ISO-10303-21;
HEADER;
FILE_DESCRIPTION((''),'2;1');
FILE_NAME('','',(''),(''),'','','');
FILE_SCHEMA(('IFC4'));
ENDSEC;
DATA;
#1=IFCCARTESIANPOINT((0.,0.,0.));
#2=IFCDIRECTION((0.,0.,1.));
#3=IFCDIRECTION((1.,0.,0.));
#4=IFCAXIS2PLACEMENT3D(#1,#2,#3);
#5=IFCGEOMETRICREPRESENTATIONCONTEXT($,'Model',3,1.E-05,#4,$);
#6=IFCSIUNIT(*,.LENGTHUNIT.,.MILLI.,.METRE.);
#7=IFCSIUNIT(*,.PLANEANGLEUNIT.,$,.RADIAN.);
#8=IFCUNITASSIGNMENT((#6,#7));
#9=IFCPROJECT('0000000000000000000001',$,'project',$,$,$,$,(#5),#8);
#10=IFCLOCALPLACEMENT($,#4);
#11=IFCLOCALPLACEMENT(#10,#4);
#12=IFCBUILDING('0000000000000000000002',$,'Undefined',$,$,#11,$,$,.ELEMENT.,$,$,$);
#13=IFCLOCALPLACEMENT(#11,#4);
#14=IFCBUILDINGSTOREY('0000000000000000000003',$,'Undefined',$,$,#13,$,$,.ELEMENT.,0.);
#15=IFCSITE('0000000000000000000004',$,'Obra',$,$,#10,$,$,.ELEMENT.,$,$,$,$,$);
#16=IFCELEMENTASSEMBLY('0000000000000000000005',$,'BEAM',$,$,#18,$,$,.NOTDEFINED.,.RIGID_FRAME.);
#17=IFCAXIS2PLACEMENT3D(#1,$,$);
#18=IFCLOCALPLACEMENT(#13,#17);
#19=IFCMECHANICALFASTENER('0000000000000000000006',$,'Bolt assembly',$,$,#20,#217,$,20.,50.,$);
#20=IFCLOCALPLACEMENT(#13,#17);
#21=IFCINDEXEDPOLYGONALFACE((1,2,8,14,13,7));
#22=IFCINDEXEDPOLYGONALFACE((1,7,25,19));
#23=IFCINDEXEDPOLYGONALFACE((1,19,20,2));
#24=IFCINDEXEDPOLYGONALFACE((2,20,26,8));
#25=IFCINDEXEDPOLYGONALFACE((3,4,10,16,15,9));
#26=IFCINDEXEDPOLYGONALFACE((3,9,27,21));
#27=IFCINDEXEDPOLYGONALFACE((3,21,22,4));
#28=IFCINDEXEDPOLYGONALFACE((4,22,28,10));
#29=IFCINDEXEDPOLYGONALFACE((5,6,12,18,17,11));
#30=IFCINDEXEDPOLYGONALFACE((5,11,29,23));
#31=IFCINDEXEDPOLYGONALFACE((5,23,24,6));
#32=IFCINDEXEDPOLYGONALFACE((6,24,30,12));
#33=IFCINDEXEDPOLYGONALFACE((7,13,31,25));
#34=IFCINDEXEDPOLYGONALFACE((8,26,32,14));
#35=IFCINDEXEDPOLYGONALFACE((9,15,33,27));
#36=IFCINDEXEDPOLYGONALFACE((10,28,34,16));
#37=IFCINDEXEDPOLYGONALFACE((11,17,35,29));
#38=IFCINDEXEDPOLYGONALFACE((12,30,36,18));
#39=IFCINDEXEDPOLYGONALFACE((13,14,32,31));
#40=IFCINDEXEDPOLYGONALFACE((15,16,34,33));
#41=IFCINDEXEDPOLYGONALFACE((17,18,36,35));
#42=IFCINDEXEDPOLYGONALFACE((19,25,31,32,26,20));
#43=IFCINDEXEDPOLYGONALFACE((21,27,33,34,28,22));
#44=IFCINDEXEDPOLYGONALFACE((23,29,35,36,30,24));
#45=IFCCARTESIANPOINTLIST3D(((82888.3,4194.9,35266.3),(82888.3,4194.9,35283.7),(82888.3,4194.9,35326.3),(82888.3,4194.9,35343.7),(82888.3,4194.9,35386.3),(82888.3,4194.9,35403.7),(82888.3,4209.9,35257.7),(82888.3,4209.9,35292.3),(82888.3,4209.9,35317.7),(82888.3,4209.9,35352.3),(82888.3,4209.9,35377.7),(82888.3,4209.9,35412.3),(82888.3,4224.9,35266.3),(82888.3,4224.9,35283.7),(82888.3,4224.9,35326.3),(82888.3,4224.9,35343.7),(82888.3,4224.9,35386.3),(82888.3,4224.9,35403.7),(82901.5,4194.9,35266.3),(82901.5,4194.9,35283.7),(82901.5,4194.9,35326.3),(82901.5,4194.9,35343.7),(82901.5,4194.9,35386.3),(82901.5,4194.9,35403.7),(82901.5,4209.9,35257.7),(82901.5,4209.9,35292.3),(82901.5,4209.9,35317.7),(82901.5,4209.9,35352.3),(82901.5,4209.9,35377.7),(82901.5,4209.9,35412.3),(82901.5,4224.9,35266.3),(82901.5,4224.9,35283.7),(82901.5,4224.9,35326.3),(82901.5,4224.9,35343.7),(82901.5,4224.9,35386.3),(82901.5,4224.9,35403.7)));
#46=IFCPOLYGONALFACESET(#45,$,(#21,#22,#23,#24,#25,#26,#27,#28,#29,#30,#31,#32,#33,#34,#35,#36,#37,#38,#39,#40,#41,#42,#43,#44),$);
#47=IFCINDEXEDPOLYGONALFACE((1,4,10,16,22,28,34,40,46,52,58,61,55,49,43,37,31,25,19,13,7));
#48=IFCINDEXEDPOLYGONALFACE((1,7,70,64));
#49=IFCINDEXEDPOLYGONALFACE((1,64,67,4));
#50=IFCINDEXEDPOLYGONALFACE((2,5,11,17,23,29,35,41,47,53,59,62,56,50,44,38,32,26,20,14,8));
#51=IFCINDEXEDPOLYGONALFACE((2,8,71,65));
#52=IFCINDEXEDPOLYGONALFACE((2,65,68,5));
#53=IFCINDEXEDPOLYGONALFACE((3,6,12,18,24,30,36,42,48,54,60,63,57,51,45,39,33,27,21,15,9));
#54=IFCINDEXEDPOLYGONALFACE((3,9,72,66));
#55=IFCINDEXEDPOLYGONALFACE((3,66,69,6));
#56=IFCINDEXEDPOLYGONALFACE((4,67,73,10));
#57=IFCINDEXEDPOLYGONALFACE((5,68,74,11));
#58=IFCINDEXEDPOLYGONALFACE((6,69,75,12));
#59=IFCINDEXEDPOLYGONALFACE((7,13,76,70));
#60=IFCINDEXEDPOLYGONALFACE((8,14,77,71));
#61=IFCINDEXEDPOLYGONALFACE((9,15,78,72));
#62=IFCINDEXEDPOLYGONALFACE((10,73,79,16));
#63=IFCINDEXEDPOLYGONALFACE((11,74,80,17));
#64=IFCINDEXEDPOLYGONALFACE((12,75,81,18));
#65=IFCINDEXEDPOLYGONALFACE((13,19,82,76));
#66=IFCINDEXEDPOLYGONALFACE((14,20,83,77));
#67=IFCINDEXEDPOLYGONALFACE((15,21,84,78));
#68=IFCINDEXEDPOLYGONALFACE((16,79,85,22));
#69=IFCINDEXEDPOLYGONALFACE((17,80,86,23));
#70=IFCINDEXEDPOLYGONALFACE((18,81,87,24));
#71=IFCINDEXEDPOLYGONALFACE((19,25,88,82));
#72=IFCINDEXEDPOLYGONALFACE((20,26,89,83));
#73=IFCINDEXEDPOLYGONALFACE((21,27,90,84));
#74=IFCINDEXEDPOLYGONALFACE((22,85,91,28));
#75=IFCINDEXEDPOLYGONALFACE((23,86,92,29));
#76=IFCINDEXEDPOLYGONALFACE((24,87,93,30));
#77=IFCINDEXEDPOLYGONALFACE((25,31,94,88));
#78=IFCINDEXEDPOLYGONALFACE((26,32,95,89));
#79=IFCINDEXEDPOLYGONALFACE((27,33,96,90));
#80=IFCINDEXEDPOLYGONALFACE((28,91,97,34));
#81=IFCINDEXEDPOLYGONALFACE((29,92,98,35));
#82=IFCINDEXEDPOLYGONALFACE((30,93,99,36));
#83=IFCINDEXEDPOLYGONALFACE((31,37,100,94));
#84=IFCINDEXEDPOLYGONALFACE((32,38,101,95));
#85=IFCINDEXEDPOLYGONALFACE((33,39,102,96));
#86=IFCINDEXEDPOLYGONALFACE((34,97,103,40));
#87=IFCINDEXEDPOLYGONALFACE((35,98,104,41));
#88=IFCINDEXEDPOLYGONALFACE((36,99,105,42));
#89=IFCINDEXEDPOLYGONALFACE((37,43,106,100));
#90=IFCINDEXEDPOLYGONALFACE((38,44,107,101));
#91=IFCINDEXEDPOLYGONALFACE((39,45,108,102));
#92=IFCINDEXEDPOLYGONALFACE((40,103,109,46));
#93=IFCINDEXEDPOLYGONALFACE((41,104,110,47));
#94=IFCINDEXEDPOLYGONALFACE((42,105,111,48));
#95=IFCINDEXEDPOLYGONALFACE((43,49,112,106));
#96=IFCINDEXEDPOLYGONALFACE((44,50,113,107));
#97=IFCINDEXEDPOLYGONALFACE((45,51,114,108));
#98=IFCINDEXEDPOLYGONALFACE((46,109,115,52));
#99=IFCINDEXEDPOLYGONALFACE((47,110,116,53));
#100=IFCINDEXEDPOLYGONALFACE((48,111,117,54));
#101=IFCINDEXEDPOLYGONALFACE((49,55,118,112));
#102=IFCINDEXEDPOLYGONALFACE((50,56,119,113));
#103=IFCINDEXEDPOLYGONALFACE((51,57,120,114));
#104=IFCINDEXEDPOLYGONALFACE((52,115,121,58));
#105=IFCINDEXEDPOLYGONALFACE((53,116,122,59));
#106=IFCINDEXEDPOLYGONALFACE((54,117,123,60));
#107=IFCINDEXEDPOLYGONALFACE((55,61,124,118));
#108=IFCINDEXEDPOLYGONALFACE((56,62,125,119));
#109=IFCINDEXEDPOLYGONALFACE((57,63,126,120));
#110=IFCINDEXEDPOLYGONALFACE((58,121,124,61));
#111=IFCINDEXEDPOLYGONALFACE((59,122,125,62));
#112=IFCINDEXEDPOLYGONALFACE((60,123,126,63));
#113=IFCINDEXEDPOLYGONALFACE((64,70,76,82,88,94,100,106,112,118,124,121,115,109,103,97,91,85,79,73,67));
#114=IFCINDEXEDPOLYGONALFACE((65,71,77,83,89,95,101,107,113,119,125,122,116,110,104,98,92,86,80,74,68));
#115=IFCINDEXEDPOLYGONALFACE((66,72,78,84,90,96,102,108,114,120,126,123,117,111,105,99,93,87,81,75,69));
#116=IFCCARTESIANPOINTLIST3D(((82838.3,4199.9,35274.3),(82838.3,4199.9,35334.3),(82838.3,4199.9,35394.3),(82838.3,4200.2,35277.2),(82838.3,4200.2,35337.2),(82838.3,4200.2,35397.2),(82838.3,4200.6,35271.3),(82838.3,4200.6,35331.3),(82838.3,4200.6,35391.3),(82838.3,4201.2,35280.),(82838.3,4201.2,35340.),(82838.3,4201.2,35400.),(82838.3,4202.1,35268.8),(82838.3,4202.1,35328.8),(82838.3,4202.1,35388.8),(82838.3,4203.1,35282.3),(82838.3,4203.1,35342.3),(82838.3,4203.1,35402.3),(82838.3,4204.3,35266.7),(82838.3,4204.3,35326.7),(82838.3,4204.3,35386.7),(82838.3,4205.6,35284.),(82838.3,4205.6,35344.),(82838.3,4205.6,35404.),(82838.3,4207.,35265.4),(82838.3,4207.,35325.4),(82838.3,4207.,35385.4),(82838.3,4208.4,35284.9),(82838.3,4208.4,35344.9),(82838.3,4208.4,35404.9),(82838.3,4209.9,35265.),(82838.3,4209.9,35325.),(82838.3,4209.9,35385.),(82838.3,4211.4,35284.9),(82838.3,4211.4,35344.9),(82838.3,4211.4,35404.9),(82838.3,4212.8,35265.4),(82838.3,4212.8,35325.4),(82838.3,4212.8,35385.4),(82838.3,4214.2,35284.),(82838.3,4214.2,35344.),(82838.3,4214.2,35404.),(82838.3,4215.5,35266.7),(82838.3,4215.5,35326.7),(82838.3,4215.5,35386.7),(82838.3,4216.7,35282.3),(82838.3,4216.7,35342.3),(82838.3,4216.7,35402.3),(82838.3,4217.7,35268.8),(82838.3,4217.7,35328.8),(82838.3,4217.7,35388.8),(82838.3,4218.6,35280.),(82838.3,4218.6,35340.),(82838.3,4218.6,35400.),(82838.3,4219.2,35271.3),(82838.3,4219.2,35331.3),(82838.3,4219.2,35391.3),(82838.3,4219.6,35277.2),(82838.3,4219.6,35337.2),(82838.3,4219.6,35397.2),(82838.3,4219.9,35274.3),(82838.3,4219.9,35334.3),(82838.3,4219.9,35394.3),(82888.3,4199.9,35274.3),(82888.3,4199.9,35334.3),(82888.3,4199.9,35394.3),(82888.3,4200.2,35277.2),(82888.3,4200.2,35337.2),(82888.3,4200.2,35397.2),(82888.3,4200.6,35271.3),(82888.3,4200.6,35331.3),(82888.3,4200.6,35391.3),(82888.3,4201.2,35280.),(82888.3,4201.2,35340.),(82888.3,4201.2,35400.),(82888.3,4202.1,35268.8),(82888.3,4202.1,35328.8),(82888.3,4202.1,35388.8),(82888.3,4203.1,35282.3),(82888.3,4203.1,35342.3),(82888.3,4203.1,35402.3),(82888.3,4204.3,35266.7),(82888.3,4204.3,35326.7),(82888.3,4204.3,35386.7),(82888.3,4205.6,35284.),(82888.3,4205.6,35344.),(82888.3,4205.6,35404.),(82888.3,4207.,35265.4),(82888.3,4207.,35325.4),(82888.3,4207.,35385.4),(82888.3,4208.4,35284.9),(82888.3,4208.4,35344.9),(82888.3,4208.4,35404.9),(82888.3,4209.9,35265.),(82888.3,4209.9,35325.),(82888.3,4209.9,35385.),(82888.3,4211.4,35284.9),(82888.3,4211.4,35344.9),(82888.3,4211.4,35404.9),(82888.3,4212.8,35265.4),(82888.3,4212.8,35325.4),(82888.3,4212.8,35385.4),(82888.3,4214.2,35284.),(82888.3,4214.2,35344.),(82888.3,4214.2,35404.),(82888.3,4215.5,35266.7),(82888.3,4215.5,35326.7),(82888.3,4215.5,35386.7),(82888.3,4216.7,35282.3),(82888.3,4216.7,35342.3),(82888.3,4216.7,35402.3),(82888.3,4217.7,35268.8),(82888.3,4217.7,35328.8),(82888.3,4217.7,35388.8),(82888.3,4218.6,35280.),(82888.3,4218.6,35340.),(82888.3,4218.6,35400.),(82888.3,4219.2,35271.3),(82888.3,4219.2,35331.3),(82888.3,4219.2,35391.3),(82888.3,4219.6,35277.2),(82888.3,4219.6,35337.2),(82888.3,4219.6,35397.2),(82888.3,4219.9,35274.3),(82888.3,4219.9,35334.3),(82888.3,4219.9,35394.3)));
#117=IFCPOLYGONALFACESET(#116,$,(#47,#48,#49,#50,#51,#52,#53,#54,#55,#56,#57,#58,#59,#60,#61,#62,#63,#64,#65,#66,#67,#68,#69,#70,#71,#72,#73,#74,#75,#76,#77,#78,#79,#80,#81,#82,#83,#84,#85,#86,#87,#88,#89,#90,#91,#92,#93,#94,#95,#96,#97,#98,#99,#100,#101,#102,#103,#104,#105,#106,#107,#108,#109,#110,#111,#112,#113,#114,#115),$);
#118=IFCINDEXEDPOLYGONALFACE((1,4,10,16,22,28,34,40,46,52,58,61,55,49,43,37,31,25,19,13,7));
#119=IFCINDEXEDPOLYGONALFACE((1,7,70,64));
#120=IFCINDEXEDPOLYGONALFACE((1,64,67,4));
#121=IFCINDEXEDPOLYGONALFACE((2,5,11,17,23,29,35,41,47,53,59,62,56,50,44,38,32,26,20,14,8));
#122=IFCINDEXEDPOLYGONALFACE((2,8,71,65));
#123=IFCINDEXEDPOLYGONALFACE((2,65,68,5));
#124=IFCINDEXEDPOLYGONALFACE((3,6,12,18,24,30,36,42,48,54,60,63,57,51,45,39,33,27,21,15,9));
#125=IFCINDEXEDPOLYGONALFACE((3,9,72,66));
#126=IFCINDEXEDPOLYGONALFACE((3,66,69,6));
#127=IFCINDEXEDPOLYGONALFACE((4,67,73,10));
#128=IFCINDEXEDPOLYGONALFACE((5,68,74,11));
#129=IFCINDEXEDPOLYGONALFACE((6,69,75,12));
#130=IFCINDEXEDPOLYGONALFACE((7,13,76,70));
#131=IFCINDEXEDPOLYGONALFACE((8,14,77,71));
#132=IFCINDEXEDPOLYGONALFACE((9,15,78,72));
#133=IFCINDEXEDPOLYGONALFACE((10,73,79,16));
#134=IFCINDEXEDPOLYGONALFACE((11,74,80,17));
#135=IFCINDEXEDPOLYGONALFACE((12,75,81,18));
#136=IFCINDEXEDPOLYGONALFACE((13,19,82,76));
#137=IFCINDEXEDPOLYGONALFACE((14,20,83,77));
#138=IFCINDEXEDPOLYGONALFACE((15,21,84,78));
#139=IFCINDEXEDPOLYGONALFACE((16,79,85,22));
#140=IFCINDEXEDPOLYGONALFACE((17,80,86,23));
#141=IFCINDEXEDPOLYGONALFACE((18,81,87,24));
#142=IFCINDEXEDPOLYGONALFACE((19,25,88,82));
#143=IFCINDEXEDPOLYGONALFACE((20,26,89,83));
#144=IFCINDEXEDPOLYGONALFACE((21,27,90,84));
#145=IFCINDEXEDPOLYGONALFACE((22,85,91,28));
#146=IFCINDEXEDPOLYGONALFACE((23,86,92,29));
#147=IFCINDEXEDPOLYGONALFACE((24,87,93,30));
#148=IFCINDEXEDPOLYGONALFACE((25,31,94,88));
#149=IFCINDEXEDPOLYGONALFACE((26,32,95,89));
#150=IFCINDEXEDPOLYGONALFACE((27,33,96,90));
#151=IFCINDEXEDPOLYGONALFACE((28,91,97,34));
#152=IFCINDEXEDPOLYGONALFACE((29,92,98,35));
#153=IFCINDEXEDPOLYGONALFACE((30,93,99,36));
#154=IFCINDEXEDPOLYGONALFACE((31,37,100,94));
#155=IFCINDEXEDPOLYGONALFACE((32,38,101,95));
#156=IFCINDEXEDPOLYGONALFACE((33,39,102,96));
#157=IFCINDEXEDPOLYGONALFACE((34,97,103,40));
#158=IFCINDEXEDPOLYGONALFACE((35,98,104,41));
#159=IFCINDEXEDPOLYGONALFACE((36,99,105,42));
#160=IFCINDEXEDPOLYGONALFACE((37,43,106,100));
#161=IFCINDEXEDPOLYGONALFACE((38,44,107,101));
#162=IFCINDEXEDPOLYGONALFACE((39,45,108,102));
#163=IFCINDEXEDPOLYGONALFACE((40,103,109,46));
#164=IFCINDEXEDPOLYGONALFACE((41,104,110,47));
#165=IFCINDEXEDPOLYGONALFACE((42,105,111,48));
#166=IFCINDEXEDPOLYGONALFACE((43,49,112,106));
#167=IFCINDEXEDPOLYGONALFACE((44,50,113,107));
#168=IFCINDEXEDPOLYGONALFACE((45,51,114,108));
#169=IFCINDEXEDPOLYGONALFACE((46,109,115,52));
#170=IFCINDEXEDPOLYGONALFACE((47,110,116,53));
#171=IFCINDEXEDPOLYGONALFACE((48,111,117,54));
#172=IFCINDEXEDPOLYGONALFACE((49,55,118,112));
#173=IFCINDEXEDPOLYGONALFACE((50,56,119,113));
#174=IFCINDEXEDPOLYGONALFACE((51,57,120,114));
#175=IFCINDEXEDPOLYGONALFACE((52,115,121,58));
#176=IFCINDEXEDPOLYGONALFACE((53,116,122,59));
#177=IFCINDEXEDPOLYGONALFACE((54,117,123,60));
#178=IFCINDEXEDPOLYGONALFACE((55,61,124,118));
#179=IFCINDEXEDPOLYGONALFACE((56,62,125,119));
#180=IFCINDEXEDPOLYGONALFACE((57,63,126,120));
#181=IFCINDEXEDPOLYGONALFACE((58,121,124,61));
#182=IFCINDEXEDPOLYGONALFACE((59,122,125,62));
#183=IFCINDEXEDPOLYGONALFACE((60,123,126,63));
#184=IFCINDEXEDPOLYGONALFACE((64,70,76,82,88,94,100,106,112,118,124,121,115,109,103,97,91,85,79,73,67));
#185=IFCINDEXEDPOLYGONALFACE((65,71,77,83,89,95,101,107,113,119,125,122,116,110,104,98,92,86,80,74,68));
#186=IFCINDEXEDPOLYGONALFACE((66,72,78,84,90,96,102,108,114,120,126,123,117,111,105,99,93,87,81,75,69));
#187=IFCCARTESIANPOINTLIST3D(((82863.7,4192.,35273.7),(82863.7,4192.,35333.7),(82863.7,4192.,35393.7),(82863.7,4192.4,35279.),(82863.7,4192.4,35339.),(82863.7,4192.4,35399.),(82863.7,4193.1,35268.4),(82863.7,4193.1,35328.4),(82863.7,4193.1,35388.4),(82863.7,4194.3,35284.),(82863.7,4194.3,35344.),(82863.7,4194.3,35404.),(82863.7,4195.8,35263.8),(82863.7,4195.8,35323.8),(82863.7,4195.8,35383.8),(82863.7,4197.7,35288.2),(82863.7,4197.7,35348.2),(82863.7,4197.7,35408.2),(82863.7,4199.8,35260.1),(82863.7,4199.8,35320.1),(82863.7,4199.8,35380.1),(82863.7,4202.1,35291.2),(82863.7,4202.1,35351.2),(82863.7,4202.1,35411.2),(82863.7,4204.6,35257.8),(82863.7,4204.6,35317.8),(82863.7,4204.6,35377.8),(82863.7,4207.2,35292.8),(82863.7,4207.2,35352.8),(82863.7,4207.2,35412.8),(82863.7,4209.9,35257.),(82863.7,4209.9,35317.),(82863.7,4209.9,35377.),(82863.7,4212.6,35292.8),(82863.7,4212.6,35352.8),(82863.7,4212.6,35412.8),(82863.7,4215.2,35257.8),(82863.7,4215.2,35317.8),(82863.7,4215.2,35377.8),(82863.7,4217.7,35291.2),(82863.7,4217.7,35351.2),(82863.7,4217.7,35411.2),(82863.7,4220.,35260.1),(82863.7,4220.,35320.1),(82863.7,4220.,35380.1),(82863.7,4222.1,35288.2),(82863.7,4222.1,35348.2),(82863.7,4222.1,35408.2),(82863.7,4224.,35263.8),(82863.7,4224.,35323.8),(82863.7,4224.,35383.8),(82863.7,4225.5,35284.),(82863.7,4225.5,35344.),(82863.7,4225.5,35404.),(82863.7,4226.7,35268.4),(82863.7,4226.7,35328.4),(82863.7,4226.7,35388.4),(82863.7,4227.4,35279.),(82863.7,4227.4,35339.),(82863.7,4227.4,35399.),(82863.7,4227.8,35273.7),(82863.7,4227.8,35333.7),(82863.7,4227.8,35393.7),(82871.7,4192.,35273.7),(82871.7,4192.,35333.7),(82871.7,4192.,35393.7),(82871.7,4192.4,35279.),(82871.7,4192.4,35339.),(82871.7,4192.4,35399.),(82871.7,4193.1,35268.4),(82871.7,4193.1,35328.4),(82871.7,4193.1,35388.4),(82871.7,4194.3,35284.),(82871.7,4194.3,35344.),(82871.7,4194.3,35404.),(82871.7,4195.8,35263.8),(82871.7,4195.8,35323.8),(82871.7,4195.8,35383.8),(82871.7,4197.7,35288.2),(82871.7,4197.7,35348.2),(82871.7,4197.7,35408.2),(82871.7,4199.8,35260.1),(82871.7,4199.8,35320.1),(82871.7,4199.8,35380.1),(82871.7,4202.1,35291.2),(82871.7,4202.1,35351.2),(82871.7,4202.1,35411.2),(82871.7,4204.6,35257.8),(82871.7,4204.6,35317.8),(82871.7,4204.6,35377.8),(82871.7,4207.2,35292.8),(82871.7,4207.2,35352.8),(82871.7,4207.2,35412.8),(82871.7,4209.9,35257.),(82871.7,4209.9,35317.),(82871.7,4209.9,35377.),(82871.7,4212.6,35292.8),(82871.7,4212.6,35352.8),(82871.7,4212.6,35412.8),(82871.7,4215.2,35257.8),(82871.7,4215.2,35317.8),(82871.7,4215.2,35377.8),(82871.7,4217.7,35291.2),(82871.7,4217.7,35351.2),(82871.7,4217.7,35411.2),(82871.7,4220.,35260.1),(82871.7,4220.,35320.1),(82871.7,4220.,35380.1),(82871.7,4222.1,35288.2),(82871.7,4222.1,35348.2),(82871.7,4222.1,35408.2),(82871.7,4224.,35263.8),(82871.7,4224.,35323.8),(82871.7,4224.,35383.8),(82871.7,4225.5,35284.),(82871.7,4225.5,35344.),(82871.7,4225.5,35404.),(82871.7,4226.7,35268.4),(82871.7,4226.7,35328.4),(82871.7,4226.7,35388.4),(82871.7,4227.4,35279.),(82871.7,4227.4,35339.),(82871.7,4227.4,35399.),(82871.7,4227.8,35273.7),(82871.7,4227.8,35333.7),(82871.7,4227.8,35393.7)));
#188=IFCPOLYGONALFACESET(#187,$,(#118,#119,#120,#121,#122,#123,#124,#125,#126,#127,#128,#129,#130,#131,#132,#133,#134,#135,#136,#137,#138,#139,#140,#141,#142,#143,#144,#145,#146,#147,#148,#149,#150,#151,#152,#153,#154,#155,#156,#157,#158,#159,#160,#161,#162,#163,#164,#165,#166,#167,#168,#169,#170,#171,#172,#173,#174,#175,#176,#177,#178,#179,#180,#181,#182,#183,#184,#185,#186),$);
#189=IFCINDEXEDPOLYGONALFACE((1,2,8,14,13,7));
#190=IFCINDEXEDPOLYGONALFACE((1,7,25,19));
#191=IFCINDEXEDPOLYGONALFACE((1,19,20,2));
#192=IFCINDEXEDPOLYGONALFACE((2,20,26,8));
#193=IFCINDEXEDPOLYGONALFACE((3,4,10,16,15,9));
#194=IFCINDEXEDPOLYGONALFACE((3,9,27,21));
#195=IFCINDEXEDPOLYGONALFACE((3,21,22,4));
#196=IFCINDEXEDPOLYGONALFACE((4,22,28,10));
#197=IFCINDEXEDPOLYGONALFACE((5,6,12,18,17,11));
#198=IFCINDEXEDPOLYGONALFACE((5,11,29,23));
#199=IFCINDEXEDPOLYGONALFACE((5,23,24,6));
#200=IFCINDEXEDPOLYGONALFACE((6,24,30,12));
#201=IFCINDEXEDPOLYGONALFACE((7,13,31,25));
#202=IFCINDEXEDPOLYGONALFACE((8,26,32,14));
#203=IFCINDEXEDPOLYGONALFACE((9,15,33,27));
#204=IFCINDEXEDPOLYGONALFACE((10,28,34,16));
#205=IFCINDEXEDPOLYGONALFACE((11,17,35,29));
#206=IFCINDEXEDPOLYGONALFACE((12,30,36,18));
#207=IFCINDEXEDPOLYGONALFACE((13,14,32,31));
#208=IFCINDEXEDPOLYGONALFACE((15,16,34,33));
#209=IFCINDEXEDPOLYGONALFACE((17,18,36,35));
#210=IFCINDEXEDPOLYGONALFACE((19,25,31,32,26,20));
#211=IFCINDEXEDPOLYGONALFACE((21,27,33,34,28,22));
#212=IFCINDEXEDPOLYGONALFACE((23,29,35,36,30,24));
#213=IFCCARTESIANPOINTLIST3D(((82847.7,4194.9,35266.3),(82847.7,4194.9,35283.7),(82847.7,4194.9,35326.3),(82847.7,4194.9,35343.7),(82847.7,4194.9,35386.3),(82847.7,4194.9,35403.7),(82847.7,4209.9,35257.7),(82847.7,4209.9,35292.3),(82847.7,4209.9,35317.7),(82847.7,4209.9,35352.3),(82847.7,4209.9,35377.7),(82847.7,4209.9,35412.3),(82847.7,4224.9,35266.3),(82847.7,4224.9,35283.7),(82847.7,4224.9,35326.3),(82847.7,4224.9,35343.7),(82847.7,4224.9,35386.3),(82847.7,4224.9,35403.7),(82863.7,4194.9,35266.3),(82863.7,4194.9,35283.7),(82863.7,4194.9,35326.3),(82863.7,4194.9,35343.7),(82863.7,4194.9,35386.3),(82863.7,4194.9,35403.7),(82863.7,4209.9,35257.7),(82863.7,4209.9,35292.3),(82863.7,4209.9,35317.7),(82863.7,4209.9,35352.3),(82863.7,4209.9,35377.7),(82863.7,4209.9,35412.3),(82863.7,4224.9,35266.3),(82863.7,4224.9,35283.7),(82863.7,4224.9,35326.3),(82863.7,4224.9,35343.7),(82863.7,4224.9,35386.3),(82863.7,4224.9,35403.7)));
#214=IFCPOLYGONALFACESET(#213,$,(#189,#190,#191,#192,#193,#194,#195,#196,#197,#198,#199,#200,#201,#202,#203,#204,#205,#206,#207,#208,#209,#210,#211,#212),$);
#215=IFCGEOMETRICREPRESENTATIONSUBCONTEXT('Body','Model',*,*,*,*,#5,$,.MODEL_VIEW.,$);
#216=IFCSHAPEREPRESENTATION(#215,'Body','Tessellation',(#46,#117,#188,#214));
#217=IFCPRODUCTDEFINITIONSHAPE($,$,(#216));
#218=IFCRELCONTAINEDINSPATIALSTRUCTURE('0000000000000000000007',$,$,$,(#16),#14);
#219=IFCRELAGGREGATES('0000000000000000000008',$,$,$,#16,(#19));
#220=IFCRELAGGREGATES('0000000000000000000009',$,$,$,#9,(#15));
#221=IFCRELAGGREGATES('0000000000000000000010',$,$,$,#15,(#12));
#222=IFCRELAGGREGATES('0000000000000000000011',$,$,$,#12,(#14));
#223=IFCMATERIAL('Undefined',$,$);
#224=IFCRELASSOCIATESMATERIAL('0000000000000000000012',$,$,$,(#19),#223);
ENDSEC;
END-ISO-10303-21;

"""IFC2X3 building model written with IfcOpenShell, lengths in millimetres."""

from ifc_helpers import new_model, si_unit, frame, origin_with_axes, origin_2d_with_axis, place, context, subcontext, project, spatial, polyline, circle, outline, extrude, source, transform, mapped, material, element, aggregate, save


model = new_model("IFC2X3")

# Units and contexts
model_context = context("Model", 3, precision=1e-05, world=origin_with_axes())
body_context = subcontext(model_context, "Body", "Model", "MODEL_VIEW")
ifc_project = project(units=[si_unit("LENGTHUNIT", "METRE", prefix="MILLI"), si_unit("PLANEANGLEUNIT", "RADIAN")], contexts=[model_context])

# Site, building, storey
site_placement = place(None, origin_with_axes())
site = spatial("IfcSite", under=ifc_project, at=site_placement, Name="Obra", CompositionType="ELEMENT")
building_placement = place(site_placement, origin_with_axes())
building = spatial("IfcBuilding", under=site, at=building_placement, Name="Undefined", CompositionType="ELEMENT")
storey_placement = place(building_placement, origin_with_axes())
storey = spatial("IfcBuildingStorey", under=building, at=storey_placement, Name="Undefined", CompositionType="ELEMENT", Elevation=0.0)

# Element assembly
assembly_1_placement = place(storey_placement, origin_with_axes())
assembly_1 = element("IfcElementAssembly", 1, at=assembly_1_placement, inside=storey, Name="BEAM", AssemblyPlace="NOTDEFINED", PredefinedType="RIGID_FRAME")

# Shared definitions
ifc_material_1 = material(Name="Undefined")
shared_shape_1 = source(origin_with_axes(), body_context, "Body", "SweptSolid", [
    extrude(outline(polyline([(17.3, 0.0), (8.7, 15.0), (-8.7, 15.0), (-17.3, 0.0), (-8.7, -15.0), (8.7, -15.0), (17.3, 0.0)])), frame((0.0, -26.5, 0.0), z_axis=(0.0, 1.0, 0.0), x_axis=(1.0, 0.0, 0.0)), (0.0, 0.0, 1.0), 13.2),
    extrude(circle(Radius=10.0, at=origin_2d_with_axis()), frame((0.0, -13.3, 0.0), z_axis=(0.0, 1.0, 0.0), x_axis=(1.0, 0.0, 0.0)), (0.0, 0.0, 1.0), 50.0),
    extrude(circle(Radius=18.0, at=origin_2d_with_axis()), frame((0.0, 3.3, 0.0), z_axis=(0.0, 1.0, 0.0), x_axis=(1.0, 0.0, 0.0)), (0.0, 0.0, 1.0), 8.0),
    extrude(outline(polyline([(17.3, 0.0), (8.7, 15.0), (-8.7, 15.0), (-17.3, 0.0), (-8.7, -15.0), (8.7, -15.0), (17.3, 0.0)])), frame((0.0, 11.3, 0.0), z_axis=(0.0, 1.0, 0.0), x_axis=(1.0, 0.0, 0.0)), (0.0, 0.0, 1.0), 16.0),
])

# Mechanical fastener
mechanical_fastener_1_placement = place(assembly_1_placement, frame((82875.0, 4159.9, 35435.0), z_axis=(0.0, 1.0, 0.0), x_axis=(0.0, 0.0, -1.0)))
mechanical_fastener_1 = element("IfcMechanicalFastener", 2, at=mechanical_fastener_1_placement, material=ifc_material_1, Name="Bolt assembly", NominalDiameter=20.0, NominalLength=50.0, context=body_context, shape_type="MappedRepresentation", body=[
    mapped(shared_shape_1, transform((40.0, 0.0, 50.0))),
    mapped(shared_shape_1, transform((100.0, 0.0, 50.0))),
    mapped(shared_shape_1, transform((160.0, 0.0, 50.0))),
])
aggregate(assembly_1, [mechanical_fastener_1])

save(model, "model.ifc")
